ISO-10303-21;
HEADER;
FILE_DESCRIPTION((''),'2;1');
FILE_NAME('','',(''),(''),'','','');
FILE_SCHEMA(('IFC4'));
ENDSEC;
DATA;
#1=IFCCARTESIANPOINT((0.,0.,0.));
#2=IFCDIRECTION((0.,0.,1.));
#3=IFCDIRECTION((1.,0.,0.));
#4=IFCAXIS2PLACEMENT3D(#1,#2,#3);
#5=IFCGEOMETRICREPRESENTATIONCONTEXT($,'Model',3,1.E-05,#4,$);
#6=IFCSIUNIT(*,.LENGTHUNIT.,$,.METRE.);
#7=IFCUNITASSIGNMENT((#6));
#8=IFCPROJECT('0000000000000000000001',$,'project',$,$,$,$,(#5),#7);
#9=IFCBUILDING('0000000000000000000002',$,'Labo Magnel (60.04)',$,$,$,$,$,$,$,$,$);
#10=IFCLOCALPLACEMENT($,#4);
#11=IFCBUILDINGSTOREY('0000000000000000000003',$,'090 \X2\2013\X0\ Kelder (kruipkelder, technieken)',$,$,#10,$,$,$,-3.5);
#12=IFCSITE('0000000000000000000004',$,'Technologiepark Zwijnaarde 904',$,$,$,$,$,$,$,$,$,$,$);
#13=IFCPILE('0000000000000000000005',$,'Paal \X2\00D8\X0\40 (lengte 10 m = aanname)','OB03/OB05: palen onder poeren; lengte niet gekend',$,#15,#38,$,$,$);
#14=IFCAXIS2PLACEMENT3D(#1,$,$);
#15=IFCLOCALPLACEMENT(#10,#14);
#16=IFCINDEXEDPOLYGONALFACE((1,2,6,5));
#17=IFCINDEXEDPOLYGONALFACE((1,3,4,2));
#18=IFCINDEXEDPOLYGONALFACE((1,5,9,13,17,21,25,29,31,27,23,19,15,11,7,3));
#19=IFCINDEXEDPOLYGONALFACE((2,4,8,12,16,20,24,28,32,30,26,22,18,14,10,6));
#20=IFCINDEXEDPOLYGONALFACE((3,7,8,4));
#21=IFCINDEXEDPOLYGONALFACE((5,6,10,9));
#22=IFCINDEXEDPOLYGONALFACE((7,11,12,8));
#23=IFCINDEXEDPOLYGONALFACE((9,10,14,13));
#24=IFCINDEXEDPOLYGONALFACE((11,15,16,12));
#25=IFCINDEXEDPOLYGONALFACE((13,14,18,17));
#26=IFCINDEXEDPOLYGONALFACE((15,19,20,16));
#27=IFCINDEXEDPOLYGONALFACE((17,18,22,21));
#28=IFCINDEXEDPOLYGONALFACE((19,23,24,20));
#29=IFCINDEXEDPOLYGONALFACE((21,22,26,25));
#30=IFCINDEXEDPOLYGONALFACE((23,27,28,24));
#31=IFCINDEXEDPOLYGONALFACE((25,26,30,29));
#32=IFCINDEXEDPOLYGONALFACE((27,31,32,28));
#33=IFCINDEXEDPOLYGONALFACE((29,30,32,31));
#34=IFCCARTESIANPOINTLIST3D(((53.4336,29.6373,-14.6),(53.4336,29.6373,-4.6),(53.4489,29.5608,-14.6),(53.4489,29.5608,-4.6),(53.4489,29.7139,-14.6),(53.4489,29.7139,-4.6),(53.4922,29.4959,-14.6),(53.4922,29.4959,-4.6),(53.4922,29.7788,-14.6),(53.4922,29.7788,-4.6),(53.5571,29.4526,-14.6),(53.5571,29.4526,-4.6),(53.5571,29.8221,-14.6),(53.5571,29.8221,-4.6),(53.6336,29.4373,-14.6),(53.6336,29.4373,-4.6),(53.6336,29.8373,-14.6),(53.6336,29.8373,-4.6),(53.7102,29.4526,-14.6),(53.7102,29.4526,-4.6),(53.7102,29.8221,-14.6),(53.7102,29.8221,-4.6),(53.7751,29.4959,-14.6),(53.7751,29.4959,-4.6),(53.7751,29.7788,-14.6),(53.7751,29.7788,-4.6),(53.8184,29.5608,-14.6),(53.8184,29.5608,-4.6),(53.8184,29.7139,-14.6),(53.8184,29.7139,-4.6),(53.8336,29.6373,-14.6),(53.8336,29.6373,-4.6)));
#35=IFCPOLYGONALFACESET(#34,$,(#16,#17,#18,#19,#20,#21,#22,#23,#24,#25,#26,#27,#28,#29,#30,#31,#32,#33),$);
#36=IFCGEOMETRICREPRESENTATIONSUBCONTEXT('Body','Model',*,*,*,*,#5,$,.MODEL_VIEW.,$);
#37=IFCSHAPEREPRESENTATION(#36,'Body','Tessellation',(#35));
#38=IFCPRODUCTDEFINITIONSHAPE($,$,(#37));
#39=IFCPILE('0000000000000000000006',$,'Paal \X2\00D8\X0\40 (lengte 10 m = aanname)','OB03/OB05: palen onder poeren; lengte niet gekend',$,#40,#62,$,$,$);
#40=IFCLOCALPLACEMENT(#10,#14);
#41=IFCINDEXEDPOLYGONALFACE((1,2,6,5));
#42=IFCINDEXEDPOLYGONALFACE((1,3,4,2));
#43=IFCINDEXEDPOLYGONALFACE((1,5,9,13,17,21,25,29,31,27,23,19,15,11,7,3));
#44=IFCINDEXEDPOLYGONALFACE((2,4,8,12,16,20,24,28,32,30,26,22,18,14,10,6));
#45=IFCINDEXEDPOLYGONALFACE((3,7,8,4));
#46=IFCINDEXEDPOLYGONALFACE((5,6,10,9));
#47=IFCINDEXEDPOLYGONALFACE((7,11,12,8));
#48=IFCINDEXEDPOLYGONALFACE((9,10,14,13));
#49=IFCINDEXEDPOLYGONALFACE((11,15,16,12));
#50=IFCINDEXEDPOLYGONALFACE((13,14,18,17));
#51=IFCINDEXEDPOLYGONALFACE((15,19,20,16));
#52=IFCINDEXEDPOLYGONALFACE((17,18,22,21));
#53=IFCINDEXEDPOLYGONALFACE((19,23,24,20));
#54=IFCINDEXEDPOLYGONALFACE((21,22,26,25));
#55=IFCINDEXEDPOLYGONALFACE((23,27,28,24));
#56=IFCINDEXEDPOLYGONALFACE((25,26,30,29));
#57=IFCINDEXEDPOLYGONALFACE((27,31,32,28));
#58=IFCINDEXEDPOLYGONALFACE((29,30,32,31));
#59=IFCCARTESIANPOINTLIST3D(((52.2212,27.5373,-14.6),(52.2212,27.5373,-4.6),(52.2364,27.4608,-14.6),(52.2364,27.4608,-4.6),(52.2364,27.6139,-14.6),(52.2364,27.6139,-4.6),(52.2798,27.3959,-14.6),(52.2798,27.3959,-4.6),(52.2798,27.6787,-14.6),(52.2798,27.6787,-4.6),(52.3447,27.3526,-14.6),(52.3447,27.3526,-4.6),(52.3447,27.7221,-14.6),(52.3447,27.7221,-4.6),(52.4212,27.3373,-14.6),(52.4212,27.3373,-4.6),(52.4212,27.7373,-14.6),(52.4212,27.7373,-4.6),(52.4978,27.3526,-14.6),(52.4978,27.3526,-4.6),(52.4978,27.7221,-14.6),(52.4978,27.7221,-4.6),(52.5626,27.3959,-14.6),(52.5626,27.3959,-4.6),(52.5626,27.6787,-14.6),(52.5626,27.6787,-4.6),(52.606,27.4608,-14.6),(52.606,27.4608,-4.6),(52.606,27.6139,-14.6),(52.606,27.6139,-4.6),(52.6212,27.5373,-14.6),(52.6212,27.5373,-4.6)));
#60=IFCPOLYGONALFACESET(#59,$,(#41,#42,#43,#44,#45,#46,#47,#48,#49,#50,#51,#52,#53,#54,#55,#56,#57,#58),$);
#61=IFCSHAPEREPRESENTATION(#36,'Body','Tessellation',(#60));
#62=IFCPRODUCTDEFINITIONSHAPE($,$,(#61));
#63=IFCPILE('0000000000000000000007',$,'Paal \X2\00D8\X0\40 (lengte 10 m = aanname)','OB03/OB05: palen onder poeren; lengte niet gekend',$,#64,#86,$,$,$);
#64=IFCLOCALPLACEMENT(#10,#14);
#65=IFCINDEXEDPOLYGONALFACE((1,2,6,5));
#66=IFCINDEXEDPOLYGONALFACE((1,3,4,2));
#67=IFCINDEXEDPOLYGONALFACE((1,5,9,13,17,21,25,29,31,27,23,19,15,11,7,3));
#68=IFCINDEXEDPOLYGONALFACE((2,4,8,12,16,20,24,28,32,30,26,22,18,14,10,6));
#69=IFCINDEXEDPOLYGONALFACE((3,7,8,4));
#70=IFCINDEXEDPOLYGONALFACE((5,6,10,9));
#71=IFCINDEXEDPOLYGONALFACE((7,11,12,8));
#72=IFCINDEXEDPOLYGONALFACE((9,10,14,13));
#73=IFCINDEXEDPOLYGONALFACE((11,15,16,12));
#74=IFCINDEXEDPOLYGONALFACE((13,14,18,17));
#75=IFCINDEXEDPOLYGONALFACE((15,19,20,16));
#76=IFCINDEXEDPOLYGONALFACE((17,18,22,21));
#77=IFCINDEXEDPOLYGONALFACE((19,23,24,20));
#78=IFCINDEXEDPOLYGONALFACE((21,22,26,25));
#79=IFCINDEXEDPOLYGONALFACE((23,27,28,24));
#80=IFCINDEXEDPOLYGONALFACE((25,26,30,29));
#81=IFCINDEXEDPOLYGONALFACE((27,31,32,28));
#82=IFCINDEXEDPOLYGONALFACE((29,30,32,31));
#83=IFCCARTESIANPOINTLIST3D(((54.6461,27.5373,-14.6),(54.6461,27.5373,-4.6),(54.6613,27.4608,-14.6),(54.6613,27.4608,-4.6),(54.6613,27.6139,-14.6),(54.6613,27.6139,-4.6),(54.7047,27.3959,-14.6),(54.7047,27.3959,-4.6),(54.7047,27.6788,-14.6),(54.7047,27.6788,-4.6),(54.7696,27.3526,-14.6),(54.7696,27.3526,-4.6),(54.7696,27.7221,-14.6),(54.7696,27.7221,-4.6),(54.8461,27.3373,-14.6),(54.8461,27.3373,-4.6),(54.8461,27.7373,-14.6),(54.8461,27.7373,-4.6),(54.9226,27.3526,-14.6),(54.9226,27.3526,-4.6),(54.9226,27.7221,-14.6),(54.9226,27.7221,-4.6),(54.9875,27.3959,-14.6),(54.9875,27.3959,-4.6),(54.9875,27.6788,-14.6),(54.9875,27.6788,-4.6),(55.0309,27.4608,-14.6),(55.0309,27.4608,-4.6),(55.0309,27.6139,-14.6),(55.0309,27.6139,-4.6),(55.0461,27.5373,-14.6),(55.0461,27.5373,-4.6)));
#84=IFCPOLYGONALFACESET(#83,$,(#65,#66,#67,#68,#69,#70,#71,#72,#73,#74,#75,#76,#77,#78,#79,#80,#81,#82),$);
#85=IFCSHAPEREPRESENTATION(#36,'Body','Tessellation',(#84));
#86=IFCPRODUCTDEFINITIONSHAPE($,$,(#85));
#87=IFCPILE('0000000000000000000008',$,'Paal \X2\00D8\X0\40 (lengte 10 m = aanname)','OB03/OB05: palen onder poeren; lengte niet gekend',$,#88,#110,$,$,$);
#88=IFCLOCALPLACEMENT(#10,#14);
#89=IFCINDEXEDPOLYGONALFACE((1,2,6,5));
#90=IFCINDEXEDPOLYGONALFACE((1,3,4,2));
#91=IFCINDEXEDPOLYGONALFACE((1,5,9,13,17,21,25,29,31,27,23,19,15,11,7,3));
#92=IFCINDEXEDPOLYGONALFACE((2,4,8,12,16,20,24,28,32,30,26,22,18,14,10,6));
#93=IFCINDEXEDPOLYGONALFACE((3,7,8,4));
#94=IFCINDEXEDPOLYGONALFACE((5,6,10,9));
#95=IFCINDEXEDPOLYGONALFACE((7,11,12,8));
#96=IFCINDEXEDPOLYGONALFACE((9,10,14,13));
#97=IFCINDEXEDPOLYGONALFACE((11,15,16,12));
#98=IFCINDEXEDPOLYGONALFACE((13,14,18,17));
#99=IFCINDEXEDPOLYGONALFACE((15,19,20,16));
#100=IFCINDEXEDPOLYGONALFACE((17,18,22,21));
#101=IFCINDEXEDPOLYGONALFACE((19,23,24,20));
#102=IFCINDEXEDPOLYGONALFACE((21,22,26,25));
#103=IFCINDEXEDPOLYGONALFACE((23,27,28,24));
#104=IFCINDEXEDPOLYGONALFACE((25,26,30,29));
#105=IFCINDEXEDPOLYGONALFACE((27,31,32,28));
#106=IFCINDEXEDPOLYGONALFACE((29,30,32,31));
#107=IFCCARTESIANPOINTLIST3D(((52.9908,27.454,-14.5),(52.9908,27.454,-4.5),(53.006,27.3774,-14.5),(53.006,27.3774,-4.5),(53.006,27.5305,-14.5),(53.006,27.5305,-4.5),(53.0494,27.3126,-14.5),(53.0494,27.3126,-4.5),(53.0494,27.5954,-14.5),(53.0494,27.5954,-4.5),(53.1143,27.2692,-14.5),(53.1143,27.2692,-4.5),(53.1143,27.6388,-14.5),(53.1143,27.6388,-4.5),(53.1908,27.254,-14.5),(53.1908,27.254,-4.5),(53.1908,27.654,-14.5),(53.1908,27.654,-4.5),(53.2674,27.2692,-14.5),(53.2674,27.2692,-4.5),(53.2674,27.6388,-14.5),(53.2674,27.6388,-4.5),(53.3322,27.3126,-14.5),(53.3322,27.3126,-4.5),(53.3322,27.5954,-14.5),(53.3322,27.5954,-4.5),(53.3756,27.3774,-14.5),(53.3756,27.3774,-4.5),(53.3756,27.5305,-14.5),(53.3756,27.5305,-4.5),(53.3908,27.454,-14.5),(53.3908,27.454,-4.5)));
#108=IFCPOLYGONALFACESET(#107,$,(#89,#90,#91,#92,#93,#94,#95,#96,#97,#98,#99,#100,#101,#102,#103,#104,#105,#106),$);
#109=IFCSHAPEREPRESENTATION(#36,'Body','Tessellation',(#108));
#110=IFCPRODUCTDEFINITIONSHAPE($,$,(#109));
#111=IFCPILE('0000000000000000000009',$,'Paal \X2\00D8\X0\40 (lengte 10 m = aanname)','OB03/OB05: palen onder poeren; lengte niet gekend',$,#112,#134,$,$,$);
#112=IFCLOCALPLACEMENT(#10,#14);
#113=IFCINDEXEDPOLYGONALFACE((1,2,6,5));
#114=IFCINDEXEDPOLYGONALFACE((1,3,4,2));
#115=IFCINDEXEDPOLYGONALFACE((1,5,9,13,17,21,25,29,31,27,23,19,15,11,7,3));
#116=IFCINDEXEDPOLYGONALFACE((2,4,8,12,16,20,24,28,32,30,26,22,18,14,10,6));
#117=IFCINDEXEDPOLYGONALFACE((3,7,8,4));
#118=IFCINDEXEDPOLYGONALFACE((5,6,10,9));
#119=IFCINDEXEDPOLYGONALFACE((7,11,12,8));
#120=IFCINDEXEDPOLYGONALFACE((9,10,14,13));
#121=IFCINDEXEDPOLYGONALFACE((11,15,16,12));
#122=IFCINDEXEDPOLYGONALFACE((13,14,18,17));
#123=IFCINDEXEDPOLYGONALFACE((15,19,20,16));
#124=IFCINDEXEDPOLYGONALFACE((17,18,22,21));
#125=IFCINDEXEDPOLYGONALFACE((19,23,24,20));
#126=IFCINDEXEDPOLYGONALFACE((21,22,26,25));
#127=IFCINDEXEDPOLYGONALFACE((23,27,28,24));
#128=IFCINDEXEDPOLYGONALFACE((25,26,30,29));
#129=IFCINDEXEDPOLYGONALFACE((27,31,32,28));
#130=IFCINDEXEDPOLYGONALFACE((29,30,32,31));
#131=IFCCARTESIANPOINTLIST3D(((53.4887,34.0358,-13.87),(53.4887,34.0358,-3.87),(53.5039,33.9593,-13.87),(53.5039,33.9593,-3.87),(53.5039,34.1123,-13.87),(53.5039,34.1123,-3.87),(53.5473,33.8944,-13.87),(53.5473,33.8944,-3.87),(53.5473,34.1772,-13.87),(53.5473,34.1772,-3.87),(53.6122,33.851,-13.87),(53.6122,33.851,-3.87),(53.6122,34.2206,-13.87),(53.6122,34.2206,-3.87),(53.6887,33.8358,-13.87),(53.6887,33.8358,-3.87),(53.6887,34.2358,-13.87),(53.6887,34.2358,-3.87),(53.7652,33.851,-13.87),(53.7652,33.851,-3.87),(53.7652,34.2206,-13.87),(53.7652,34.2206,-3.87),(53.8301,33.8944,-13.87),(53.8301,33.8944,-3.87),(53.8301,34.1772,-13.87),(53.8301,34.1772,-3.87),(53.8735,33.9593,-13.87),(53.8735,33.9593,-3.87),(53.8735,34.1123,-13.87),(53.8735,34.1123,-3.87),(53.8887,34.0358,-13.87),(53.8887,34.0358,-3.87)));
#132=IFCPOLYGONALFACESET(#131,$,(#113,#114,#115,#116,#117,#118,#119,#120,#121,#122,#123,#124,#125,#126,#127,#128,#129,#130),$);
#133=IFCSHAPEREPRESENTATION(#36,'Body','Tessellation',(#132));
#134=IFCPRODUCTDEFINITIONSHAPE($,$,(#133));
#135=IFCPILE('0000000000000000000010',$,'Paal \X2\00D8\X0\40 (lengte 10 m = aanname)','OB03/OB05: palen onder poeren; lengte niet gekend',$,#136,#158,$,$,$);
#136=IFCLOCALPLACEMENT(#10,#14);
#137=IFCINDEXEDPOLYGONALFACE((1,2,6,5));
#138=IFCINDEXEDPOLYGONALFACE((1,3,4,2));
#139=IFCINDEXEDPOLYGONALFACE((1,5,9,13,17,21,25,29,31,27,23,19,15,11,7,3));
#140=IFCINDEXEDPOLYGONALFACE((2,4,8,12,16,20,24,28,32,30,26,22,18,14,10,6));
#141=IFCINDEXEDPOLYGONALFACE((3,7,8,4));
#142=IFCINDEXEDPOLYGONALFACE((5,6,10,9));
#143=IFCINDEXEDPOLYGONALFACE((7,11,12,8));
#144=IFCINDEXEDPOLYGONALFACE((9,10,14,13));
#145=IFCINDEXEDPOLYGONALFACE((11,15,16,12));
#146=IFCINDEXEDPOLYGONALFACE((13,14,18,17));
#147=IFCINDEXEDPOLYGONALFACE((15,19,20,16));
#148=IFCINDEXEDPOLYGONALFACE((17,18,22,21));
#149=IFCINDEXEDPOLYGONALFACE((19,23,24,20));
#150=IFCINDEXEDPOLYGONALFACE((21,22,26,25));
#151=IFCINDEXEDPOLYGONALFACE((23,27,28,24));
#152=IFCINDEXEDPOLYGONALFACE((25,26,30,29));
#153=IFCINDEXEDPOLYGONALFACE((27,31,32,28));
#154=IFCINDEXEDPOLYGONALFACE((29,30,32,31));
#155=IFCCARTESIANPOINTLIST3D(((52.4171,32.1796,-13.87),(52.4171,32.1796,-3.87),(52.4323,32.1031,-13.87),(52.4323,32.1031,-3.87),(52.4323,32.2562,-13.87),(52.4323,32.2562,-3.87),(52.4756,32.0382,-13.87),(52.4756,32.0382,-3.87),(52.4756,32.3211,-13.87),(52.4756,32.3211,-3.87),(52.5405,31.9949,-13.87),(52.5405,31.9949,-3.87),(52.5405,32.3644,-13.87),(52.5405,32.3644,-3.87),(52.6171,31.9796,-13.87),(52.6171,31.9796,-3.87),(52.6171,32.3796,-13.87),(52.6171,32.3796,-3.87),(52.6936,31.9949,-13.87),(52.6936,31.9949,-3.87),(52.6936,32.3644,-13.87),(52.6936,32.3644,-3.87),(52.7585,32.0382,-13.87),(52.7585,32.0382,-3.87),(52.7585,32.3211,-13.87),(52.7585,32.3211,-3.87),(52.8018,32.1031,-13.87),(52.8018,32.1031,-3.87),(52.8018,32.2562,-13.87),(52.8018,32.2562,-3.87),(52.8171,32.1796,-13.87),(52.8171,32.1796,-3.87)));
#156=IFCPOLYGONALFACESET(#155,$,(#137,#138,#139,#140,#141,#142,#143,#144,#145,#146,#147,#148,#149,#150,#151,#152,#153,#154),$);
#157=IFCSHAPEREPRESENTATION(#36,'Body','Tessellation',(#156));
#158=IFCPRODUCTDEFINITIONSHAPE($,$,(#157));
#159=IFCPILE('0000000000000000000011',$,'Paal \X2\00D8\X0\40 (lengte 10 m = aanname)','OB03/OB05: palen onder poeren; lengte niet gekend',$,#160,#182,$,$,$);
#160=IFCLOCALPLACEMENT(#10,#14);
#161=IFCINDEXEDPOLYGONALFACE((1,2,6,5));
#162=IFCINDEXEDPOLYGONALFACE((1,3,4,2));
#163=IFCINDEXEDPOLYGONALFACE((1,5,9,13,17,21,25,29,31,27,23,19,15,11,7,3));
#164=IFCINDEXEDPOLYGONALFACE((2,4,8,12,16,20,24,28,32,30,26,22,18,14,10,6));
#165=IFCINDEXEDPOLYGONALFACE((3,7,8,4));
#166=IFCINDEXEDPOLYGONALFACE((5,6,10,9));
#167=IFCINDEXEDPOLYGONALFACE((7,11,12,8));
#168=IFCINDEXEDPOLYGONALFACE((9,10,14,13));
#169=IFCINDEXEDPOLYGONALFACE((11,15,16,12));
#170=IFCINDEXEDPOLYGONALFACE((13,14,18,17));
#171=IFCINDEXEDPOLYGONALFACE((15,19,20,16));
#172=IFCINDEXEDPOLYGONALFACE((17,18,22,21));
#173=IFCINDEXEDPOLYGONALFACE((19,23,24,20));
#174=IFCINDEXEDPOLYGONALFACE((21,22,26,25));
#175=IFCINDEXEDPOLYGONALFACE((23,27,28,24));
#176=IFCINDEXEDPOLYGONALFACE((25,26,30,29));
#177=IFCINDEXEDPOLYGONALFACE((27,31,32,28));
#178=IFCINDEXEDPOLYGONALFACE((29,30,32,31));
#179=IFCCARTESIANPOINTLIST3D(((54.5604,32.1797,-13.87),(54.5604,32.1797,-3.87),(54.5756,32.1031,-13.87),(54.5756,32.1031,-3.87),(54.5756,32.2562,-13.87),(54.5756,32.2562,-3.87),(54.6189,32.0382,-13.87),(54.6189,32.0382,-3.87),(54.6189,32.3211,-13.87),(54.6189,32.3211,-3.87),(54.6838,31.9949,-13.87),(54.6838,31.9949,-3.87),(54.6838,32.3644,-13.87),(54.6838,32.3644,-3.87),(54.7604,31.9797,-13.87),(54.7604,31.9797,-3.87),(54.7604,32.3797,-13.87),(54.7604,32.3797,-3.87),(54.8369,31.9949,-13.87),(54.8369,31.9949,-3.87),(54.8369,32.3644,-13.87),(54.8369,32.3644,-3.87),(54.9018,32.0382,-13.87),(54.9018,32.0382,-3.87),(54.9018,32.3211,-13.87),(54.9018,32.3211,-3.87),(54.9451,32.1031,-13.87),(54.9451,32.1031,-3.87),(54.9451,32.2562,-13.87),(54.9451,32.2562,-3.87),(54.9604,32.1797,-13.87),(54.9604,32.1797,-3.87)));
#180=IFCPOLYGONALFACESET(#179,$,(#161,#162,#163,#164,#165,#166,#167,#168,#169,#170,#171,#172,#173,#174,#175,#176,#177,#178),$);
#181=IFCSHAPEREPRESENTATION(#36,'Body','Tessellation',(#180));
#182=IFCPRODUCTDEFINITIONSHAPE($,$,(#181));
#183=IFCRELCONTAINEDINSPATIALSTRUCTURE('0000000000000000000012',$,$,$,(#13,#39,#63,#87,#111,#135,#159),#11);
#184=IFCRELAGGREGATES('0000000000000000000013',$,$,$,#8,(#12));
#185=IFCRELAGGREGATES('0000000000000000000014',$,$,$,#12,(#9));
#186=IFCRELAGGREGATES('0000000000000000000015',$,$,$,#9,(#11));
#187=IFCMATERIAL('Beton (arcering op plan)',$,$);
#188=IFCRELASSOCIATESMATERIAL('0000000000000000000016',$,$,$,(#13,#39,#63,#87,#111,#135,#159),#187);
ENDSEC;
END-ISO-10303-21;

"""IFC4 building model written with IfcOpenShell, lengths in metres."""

from ifc_helpers import new_model, si_unit, frame, origin, origin_with_axes, place, context, subcontext, project, spatial, polyline, outline, extrude, material, element, save


model = new_model("IFC4")

# Units and contexts
model_context = context("Model", 3, precision=1e-05, world=origin_with_axes())
body_context = subcontext(model_context, "Body", "Model", "MODEL_VIEW")
ifc_project = project(units=[si_unit("LENGTHUNIT", "METRE")], contexts=[model_context])

# Site, building, storey
site = spatial("IfcSite", under=ifc_project, Name="Technologiepark Zwijnaarde 904")
building = spatial("IfcBuilding", under=site, Name="Labo Magnel (60.04)")
storey_placement = place(None, origin_with_axes())
storey = spatial("IfcBuildingStorey", under=building, at=storey_placement, Name="090 – Kelder (kruipkelder, technieken)", Elevation=-3.5)

# Piles
ifc_material = material(Name="Beton (arcering op plan)")
pile_1_placement = place(storey_placement, frame((0.0, 0.0, -14.6), z_axis=(0.0, 0.0, 1.0), x_axis=(1.0, 0.0, 0.0)))
element("IfcPile", 1, at=pile_1_placement, inside=storey, material=ifc_material, Name="Paal Ø40 (lengte 10 m = aanname)", Description="OB03/OB05: palen onder poeren; lengte niet gekend", context=body_context, shape_type="SweptSolid", body=[
    extrude(outline(polyline([(53.8336, 29.6373), (53.8184, 29.5608), (53.7751, 29.4959), (53.7102, 29.4526), (53.6336, 29.4373), (53.5571, 29.4526), (53.4922, 29.4959), (53.4489, 29.5608), (53.4336, 29.6373), (53.4489, 29.7139), (53.4922, 29.7788), (53.5571, 29.8221), (53.6336, 29.8373), (53.7102, 29.8221), (53.7751, 29.7788), (53.8184, 29.7139), (53.8336, 29.6373)])), origin(), (0.0, 0.0, 1.0), 10.0),
])
pile_2_placement = place(storey_placement, frame((0.0, 0.0, -14.6), z_axis=(0.0, 0.0, 1.0), x_axis=(1.0, 0.0, 0.0)))
element("IfcPile", 2, at=pile_2_placement, inside=storey, material=ifc_material, Name="Paal Ø40 (lengte 10 m = aanname)", Description="OB03/OB05: palen onder poeren; lengte niet gekend", context=body_context, shape_type="SweptSolid", body=[
    extrude(outline(polyline([(52.6212, 27.5373), (52.606, 27.4608), (52.5626, 27.3959), (52.4978, 27.3526), (52.4212, 27.3373), (52.3447, 27.3526), (52.2798, 27.3959), (52.2364, 27.4608), (52.2212, 27.5373), (52.2364, 27.6139), (52.2798, 27.6787), (52.3447, 27.7221), (52.4212, 27.7373), (52.4978, 27.7221), (52.5626, 27.6787), (52.606, 27.6139), (52.6212, 27.5373)])), origin(), (0.0, 0.0, 1.0), 10.0),
])
pile_3_placement = place(storey_placement, frame((0.0, 0.0, -14.6), z_axis=(0.0, 0.0, 1.0), x_axis=(1.0, 0.0, 0.0)))
element("IfcPile", 3, at=pile_3_placement, inside=storey, material=ifc_material, Name="Paal Ø40 (lengte 10 m = aanname)", Description="OB03/OB05: palen onder poeren; lengte niet gekend", context=body_context, shape_type="SweptSolid", body=[
    extrude(outline(polyline([(55.0461, 27.5373), (55.0309, 27.4608), (54.9875, 27.3959), (54.9226, 27.3526), (54.8461, 27.3373), (54.7696, 27.3526), (54.7047, 27.3959), (54.6613, 27.4608), (54.6461, 27.5373), (54.6613, 27.6139), (54.7047, 27.6788), (54.7696, 27.7221), (54.8461, 27.7373), (54.9226, 27.7221), (54.9875, 27.6788), (55.0309, 27.6139), (55.0461, 27.5373)])), origin(), (0.0, 0.0, 1.0), 10.0),
])
pile_4_placement = place(storey_placement, frame((0.0, 0.0, -14.5), z_axis=(0.0, 0.0, 1.0), x_axis=(1.0, 0.0, 0.0)))
element("IfcPile", 4, at=pile_4_placement, inside=storey, material=ifc_material, Name="Paal Ø40 (lengte 10 m = aanname)", Description="OB03/OB05: palen onder poeren; lengte niet gekend", context=body_context, shape_type="SweptSolid", body=[
    extrude(outline(polyline([(53.3908, 27.454), (53.3756, 27.3774), (53.3322, 27.3126), (53.2674, 27.2692), (53.1908, 27.254), (53.1143, 27.2692), (53.0494, 27.3126), (53.006, 27.3774), (52.9908, 27.454), (53.006, 27.5305), (53.0494, 27.5954), (53.1143, 27.6388), (53.1908, 27.654), (53.2674, 27.6388), (53.3322, 27.5954), (53.3756, 27.5305), (53.3908, 27.454)])), origin(), (0.0, 0.0, 1.0), 10.0),
])
pile_5_placement = place(storey_placement, frame((0.0, 0.0, -13.87), z_axis=(0.0, 0.0, 1.0), x_axis=(1.0, 0.0, 0.0)))
element("IfcPile", 5, at=pile_5_placement, inside=storey, material=ifc_material, Name="Paal Ø40 (lengte 10 m = aanname)", Description="OB03/OB05: palen onder poeren; lengte niet gekend", context=body_context, shape_type="SweptSolid", body=[
    extrude(outline(polyline([(53.8887, 34.0358), (53.8735, 33.9593), (53.8301, 33.8944), (53.7652, 33.851), (53.6887, 33.8358), (53.6122, 33.851), (53.5473, 33.8944), (53.5039, 33.9593), (53.4887, 34.0358), (53.5039, 34.1123), (53.5473, 34.1772), (53.6122, 34.2206), (53.6887, 34.2358), (53.7652, 34.2206), (53.8301, 34.1772), (53.8735, 34.1123), (53.8887, 34.0358)])), origin(), (0.0, 0.0, 1.0), 10.0),
])
pile_6_placement = place(storey_placement, frame((0.0, 0.0, -13.87), z_axis=(0.0, 0.0, 1.0), x_axis=(1.0, 0.0, 0.0)))
element("IfcPile", 6, at=pile_6_placement, inside=storey, material=ifc_material, Name="Paal Ø40 (lengte 10 m = aanname)", Description="OB03/OB05: palen onder poeren; lengte niet gekend", context=body_context, shape_type="SweptSolid", body=[
    extrude(outline(polyline([(52.8171, 32.1796), (52.8018, 32.1031), (52.7585, 32.0382), (52.6936, 31.9949), (52.6171, 31.9796), (52.5405, 31.9949), (52.4756, 32.0382), (52.4323, 32.1031), (52.4171, 32.1796), (52.4323, 32.2562), (52.4756, 32.3211), (52.5405, 32.3644), (52.6171, 32.3796), (52.6936, 32.3644), (52.7585, 32.3211), (52.8018, 32.2562), (52.8171, 32.1796)])), origin(), (0.0, 0.0, 1.0), 10.0),
])
pile_7_placement = place(storey_placement, frame((0.0, 0.0, -13.87), z_axis=(0.0, 0.0, 1.0), x_axis=(1.0, 0.0, 0.0)))
element("IfcPile", 7, at=pile_7_placement, inside=storey, material=ifc_material, Name="Paal Ø40 (lengte 10 m = aanname)", Description="OB03/OB05: palen onder poeren; lengte niet gekend", context=body_context, shape_type="SweptSolid", body=[
    extrude(outline(polyline([(54.9604, 32.1797), (54.9451, 32.1031), (54.9018, 32.0382), (54.8369, 31.9949), (54.7604, 31.9797), (54.6838, 31.9949), (54.6189, 32.0382), (54.5756, 32.1031), (54.5604, 32.1797), (54.5756, 32.2562), (54.6189, 32.3211), (54.6838, 32.3644), (54.7604, 32.3797), (54.8369, 32.3644), (54.9018, 32.3211), (54.9451, 32.2562), (54.9604, 32.1797)])), origin(), (0.0, 0.0, 1.0), 10.0),
])

save(model, "model.ifc")
